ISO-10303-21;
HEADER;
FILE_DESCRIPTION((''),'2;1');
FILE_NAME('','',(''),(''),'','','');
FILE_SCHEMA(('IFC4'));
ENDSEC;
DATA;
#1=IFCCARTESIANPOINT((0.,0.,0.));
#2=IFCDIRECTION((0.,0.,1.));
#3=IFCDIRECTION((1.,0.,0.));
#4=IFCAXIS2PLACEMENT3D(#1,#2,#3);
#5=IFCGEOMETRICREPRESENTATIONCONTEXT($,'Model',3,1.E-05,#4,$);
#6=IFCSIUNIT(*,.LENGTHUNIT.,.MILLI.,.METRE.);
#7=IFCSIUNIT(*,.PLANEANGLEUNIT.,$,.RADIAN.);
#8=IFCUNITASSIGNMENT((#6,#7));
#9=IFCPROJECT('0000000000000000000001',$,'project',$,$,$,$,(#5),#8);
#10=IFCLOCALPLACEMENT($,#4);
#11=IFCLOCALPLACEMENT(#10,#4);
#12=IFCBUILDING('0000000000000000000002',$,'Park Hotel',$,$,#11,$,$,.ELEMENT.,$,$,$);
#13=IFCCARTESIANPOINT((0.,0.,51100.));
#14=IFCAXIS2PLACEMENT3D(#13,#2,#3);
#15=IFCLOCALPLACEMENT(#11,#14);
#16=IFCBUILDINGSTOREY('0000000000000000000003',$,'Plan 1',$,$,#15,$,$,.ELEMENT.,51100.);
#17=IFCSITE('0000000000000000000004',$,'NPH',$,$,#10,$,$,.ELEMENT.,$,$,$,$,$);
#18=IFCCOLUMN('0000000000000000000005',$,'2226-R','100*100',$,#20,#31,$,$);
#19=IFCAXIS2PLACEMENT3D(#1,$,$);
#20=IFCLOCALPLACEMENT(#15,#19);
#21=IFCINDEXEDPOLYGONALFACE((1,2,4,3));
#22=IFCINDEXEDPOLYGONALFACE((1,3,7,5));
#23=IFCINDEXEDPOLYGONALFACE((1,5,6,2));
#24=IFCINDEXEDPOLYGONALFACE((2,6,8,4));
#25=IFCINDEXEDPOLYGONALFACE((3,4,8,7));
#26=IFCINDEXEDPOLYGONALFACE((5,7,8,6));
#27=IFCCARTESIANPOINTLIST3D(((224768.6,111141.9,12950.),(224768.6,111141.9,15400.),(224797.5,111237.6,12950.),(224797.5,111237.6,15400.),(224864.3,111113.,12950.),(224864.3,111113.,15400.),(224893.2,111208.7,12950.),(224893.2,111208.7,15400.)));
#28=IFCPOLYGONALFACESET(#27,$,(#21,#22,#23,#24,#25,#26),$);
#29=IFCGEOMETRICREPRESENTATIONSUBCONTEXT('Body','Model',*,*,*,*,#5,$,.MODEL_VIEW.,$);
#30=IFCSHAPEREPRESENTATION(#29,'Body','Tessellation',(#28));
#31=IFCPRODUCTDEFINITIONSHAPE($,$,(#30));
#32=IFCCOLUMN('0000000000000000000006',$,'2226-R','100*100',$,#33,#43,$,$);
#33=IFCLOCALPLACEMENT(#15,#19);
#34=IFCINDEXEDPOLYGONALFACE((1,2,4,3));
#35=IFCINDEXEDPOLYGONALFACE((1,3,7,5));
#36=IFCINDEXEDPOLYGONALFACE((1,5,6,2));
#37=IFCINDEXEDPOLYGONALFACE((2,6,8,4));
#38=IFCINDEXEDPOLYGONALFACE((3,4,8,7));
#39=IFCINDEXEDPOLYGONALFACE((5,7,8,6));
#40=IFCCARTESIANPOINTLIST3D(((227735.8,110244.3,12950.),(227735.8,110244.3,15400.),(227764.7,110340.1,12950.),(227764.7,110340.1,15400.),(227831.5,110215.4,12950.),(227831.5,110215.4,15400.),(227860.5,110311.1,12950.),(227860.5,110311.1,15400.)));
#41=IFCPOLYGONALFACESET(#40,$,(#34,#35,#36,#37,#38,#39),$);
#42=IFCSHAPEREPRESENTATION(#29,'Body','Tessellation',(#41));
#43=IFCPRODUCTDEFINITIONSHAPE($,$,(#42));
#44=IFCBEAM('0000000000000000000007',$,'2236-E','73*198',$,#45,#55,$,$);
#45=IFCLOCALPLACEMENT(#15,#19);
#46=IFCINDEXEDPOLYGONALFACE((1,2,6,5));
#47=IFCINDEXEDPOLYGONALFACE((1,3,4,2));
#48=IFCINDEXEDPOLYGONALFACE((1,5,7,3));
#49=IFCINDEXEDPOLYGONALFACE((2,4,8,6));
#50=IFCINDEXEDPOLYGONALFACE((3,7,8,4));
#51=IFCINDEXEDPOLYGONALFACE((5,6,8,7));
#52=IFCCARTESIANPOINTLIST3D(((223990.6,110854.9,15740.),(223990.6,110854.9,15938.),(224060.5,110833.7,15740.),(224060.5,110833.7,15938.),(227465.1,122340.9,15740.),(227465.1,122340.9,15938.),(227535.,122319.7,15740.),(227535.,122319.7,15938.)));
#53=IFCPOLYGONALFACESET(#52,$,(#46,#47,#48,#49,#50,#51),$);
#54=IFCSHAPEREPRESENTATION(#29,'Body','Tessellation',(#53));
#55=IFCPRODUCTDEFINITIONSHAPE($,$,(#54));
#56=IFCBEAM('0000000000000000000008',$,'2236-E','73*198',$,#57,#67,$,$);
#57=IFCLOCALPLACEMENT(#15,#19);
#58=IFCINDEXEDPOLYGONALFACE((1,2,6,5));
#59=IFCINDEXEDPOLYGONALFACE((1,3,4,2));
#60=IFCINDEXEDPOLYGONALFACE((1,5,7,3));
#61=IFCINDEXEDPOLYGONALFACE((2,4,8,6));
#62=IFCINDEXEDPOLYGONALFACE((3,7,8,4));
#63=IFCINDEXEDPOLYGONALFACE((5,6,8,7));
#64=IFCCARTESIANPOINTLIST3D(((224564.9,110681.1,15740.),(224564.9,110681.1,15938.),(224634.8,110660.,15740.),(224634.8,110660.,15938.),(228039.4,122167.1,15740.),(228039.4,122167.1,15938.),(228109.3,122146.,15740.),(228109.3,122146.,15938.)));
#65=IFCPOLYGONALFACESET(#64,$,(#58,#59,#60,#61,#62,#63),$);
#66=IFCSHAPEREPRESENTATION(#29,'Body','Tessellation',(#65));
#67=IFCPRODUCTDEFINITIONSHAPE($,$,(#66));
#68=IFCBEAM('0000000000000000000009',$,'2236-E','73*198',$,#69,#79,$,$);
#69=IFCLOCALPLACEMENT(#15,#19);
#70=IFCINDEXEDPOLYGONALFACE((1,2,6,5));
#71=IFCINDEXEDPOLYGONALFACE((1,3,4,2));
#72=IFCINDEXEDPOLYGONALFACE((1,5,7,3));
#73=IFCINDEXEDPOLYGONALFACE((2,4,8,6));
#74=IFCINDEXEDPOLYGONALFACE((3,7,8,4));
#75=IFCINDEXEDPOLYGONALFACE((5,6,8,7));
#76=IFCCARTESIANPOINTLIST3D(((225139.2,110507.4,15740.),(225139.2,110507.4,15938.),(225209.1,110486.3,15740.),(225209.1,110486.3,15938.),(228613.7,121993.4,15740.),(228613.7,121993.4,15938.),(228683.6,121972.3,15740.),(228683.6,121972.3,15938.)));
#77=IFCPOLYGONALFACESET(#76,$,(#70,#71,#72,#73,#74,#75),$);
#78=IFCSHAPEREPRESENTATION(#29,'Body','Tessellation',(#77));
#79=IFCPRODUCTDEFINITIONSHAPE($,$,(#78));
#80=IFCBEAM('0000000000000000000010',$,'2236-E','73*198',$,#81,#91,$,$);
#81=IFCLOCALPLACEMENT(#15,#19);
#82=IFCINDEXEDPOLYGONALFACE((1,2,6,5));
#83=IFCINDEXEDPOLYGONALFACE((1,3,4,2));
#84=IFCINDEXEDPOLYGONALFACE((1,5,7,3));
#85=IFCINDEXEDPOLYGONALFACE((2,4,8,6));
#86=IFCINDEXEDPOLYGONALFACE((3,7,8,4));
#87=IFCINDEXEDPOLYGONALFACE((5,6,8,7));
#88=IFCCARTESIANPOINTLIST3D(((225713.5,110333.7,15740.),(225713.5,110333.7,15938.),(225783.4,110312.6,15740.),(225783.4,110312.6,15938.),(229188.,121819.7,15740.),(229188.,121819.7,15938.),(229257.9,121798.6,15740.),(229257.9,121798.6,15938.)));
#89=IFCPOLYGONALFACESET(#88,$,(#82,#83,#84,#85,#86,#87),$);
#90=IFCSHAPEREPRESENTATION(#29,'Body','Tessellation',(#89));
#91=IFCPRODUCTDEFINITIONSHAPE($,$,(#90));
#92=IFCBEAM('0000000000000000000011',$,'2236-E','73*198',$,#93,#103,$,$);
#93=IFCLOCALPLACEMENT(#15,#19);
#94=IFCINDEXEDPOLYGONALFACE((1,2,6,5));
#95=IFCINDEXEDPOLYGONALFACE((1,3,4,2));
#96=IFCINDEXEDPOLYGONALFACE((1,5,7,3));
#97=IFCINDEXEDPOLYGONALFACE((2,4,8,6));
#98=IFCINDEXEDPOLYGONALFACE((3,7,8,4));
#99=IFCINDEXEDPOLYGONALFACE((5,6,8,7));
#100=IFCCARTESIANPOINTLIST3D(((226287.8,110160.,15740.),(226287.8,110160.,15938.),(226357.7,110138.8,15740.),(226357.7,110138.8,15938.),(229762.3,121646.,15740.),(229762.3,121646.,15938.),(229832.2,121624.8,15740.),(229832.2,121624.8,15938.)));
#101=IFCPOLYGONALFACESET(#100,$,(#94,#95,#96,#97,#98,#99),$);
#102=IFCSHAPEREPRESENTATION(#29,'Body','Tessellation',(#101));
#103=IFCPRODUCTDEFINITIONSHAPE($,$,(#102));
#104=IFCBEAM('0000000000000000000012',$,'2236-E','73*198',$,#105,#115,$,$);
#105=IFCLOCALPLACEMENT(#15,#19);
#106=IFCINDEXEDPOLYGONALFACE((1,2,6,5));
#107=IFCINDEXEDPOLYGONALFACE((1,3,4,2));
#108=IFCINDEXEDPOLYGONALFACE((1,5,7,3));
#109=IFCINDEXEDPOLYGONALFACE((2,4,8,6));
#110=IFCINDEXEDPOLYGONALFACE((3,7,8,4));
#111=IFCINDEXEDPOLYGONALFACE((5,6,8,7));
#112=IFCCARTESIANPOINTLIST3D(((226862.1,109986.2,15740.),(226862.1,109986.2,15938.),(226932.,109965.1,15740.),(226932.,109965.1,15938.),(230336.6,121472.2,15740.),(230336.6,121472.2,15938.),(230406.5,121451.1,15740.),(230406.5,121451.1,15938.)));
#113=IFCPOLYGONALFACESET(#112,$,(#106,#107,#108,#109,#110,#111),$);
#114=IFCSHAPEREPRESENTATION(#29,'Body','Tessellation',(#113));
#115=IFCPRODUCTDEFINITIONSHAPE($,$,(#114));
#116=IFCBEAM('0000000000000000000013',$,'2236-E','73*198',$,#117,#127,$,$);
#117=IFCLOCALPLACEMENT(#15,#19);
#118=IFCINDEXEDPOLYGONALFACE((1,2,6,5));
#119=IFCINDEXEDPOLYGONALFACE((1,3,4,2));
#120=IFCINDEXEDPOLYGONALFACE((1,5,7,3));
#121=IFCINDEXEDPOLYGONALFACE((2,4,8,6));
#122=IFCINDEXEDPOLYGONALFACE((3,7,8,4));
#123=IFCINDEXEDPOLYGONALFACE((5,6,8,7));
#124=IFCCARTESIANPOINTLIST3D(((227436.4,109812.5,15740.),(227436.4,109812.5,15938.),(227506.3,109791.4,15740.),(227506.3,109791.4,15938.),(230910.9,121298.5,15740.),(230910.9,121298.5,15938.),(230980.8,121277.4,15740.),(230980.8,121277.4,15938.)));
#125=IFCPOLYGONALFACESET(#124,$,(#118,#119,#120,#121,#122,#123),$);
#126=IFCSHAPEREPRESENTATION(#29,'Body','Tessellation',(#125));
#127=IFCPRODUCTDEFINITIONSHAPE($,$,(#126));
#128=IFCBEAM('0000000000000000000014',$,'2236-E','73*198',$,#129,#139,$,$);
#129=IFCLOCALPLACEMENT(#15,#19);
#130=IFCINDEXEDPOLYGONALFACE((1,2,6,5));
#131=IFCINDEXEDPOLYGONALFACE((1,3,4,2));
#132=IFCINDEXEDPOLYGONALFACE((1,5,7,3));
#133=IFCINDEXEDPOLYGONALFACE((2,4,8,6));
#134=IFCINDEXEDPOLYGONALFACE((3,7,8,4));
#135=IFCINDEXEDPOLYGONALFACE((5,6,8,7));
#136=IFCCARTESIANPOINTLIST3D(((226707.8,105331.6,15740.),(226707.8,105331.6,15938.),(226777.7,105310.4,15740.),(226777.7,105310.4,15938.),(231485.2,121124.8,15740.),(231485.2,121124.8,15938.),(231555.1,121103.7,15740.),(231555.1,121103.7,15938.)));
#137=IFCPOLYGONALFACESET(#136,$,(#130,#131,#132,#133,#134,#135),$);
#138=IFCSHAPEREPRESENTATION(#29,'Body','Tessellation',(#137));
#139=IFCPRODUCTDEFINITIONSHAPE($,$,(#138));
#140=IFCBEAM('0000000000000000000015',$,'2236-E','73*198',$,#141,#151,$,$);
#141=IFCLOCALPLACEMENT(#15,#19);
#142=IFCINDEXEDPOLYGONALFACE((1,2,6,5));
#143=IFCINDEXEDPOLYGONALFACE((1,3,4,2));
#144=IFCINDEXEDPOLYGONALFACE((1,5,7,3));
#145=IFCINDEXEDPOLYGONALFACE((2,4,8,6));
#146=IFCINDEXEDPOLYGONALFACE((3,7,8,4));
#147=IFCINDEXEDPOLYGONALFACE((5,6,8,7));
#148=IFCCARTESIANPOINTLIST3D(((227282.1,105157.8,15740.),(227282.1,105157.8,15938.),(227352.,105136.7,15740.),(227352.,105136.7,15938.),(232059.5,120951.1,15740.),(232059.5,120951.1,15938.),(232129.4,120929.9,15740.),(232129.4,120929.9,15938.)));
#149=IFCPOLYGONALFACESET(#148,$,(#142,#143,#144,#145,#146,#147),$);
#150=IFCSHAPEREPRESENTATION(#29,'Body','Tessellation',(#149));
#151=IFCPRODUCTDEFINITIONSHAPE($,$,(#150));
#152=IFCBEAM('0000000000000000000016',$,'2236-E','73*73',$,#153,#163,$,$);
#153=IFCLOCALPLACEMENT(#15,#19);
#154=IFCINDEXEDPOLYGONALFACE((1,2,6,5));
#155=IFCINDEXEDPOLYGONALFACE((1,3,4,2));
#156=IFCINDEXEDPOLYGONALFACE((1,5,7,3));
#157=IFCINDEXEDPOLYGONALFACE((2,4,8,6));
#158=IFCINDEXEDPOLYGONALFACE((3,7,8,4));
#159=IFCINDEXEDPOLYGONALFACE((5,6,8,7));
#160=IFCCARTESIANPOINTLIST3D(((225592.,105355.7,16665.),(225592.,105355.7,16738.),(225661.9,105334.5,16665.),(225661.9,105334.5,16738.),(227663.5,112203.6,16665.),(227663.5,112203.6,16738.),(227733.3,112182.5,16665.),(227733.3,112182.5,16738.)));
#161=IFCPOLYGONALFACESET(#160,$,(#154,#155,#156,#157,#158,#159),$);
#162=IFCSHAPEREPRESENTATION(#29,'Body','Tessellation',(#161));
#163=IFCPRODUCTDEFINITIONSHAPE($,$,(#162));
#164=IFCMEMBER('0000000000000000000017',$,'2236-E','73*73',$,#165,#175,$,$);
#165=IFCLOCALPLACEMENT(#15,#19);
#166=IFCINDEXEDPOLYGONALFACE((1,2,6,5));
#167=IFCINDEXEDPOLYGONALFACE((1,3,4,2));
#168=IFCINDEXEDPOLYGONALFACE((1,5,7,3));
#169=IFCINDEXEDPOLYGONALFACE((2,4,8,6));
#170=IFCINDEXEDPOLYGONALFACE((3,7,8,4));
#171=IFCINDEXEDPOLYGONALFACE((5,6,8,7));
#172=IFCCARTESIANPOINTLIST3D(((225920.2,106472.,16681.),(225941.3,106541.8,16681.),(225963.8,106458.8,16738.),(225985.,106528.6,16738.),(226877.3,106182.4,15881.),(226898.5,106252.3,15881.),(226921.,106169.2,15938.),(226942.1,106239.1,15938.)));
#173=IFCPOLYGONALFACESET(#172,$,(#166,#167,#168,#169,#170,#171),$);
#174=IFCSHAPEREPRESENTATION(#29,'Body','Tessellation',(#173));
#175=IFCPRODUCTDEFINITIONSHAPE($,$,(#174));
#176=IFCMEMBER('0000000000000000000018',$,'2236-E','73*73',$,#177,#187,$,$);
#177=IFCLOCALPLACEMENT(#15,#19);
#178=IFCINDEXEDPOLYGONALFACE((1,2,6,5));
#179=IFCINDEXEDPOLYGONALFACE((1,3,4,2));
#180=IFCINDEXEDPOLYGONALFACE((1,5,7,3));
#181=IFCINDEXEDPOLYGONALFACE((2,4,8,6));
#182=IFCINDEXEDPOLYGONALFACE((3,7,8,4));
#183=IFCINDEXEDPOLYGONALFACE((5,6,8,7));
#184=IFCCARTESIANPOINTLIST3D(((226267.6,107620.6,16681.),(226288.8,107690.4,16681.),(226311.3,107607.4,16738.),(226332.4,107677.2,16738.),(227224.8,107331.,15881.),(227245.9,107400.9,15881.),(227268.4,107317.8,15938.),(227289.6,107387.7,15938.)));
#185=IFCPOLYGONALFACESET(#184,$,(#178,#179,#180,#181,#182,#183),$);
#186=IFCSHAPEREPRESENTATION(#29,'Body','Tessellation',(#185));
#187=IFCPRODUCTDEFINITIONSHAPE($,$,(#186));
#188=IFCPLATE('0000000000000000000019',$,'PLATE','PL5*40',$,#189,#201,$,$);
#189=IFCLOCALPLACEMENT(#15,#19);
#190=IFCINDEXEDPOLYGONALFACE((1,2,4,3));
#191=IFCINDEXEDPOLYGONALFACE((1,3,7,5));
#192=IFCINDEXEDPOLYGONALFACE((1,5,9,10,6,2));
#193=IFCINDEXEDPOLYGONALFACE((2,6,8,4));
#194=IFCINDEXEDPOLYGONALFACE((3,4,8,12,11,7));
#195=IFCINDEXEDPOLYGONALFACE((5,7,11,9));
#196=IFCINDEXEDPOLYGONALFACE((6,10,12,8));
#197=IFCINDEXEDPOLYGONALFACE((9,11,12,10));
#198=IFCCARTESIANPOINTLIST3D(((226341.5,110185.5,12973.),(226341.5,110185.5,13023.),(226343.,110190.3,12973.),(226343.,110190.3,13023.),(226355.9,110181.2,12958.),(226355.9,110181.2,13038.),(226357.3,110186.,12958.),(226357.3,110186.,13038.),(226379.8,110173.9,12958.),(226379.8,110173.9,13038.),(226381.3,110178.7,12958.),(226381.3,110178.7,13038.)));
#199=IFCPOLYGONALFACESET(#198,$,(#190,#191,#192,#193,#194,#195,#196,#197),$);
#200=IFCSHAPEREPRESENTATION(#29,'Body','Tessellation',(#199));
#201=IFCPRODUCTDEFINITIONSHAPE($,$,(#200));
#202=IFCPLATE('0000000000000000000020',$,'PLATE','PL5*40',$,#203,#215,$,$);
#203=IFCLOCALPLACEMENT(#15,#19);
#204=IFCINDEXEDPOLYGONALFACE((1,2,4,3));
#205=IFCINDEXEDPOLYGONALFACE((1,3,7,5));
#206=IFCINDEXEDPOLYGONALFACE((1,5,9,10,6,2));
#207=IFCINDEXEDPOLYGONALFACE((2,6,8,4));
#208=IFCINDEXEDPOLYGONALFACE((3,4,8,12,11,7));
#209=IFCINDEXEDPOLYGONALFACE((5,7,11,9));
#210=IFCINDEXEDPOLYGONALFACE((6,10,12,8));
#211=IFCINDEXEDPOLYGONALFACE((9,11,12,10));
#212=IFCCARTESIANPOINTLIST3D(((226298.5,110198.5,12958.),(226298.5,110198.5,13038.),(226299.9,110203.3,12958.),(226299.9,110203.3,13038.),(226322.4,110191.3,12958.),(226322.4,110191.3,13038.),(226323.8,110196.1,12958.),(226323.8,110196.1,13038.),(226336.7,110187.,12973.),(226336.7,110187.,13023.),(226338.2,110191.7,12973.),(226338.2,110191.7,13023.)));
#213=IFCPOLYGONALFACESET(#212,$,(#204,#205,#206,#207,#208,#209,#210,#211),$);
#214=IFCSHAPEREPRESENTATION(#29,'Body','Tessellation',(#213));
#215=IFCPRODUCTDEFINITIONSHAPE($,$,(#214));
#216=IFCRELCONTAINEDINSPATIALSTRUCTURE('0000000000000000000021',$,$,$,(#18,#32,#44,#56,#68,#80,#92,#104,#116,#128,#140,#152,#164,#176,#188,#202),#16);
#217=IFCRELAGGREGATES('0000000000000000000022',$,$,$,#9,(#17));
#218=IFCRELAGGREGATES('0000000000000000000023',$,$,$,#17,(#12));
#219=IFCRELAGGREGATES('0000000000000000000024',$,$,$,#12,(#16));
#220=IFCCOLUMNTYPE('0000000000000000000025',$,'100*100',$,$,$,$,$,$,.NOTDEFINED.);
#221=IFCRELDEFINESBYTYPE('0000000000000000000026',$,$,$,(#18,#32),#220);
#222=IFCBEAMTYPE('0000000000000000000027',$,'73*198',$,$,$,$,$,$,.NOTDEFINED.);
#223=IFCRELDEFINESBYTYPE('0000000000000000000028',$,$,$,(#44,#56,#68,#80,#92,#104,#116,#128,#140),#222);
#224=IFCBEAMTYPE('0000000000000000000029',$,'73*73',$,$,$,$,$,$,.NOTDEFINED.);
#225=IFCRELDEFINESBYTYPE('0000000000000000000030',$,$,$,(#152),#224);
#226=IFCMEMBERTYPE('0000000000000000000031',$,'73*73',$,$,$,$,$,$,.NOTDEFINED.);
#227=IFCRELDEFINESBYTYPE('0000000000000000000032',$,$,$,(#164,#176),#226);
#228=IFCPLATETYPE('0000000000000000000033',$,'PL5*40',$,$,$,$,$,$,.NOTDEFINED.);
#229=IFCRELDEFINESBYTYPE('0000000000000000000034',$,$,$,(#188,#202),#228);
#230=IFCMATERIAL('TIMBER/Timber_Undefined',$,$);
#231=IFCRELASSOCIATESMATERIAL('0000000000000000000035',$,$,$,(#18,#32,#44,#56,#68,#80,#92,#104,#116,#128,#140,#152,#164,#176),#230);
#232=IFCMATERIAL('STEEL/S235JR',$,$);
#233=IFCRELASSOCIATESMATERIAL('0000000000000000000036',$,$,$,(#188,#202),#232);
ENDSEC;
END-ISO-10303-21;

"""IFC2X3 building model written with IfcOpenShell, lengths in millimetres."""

from ifc_helpers import new_model, si_unit, frame, origin_with_axes, origin_2d_with_axis, place, context, subcontext, project, spatial, polyline, rectangle, outline, extrude, material, type_object, element, save


model = new_model("IFC2X3")

# Units and contexts
model_context = context("Model", 3, precision=1e-05, world=origin_with_axes())
body_context = subcontext(model_context, "Body", "Model", "MODEL_VIEW")
ifc_project = project(units=[si_unit("LENGTHUNIT", "METRE", prefix="MILLI"), si_unit("PLANEANGLEUNIT", "RADIAN")], contexts=[model_context])

# Site, building, storey
site_placement = place(None, origin_with_axes())
site = spatial("IfcSite", under=ifc_project, at=site_placement, Name="NPH", CompositionType="ELEMENT")
building_placement = place(site_placement, origin_with_axes())
building = spatial("IfcBuilding", under=site, at=building_placement, Name="Park Hotel", CompositionType="ELEMENT")
storey_placement = place(building_placement, frame((0.0, 0.0, 51100.0), z_axis=(0.0, 0.0, 1.0), x_axis=(1.0, 0.0, 0.0)))
storey = spatial("IfcBuildingStorey", under=building, at=storey_placement, Name="Plan 1", CompositionType="ELEMENT", Elevation=51100.0)

# Columns
ifc_material_1 = material(Name="TIMBER/Timber_Undefined")
column_type = type_object("IfcColumnType", Name="100*100", PredefinedType="NOTDEFINED")
for number, where, z_axis, x_axis, name in (
    (1, (224830.9, 111175.3, 15400.0), (0.0, 0.0, -1.0), (0.289538, 0.957167, 0.0), "2226-R"),
    (2, (227798.1, 110277.7, 15400.0), (0.0, 0.0, -1.0), (0.289538, 0.957167, 0.0), "2226-R"),
):
    element("IfcColumn", number, at=place(storey_placement, frame(where, z_axis=z_axis, x_axis=x_axis)), inside=storey, type_object=column_type, material=ifc_material_1, Name=name, Description="100*100", context=body_context, shape_type="SweptSolid", body=[
        extrude(rectangle(XDim=100.0, YDim=100.0, at=origin_2d_with_axis()), frame((0.0, 0.0, 2450.0), z_axis=(0.0, 0.0, -1.0), x_axis=(0.0, 1.0, 0.0)), (0.0, 0.0, 1.0), 2450.0),
    ])

# Beams
beam_type_1 = type_object("IfcBeamType", Name="73*198", PredefinedType="NOTDEFINED")
for number, where, z_axis, x_axis, name in (
    (3, (224025.6, 110844.3, 15839.0), (-0.957167, 0.289538, 0.0), (0.289538, 0.957167, 0.0), "2236-E"),
    (4, (224599.9, 110670.6, 15839.0), (-0.957167, 0.289538, 0.0), (0.289538, 0.957167, 0.0), "2236-E"),
    (5, (225174.2, 110496.8, 15839.0), (-0.957167, 0.289538, 0.0), (0.289538, 0.957167, 0.0), "2236-E"),
    (6, (225748.5, 110323.1, 15839.0), (-0.957167, 0.289538, 0.0), (0.289538, 0.957167, 0.0), "2236-E"),
    (7, (226322.8, 110149.4, 15839.0), (-0.957167, 0.289538, 0.0), (0.289538, 0.957167, 0.0), "2236-E"),
    (8, (226897.1, 109975.7, 15839.0), (-0.957167, 0.289538, 0.0), (0.289538, 0.957167, 0.0), "2236-E"),
    (9, (227471.4, 109802.0, 15839.0), (-0.957167, 0.289538, 0.0), (0.289538, 0.957167, 0.0), "2236-E"),
):
    element("IfcBeam", number, at=place(storey_placement, frame(where, z_axis=z_axis, x_axis=x_axis)), inside=storey, type_object=beam_type_1, material=ifc_material_1, Name=name, Description="73*198", context=body_context, shape_type="SweptSolid", body=[
        extrude(rectangle(XDim=198.0, YDim=73.0, at=origin_2d_with_axis()), frame((12000.0, 0.0, 0.0), z_axis=(-1.0, 0.0, 0.0), x_axis=(0.0, -1.0, 0.0)), (0.0, 0.0, 1.0), 12000.0),
    ])
for number, where, z_axis, x_axis, name in (
    (10, (226742.8, 105321.0, 15839.0), (-0.957167, 0.289538, 0.0), (0.289538, 0.957167, 0.0), "2236-E"),
    (11, (227317.1, 105147.3, 15839.0), (-0.957167, 0.289538, 0.0), (0.289538, 0.957167, 0.0), "2236-E"),
):
    element("IfcBeam", number, at=place(storey_placement, frame(where, z_axis=z_axis, x_axis=x_axis)), inside=storey, type_object=beam_type_1, material=ifc_material_1, Name=name, Description="73*198", context=body_context, shape_type="SweptSolid", body=[
        extrude(rectangle(XDim=198.0, YDim=73.0, at=origin_2d_with_axis()), frame((16500.0, 0.0, 0.0), z_axis=(-1.0, 0.0, 0.0), x_axis=(0.0, -1.0, 0.0)), (0.0, 0.0, 1.0), 16500.0),
    ])
beam_type_2 = type_object("IfcBeamType", Name="73*73", PredefinedType="NOTDEFINED")
beam_1_placement = place(storey_placement, frame((225626.9, 105345.1, 16701.5), z_axis=(-0.957167, 0.289538, 0.0), x_axis=(0.289538, 0.957167, 0.0)))
element("IfcBeam", 12, at=beam_1_placement, inside=storey, type_object=beam_type_2, material=ifc_material_1, Name="2236-E", Description="73*73", context=body_context, shape_type="SweptSolid", body=[
    extrude(rectangle(XDim=73.0, YDim=73.0, at=origin_2d_with_axis()), frame((7154.4, 0.0, 0.0), z_axis=(-1.0, 0.0, 0.0), x_axis=(0.0, -1.0, 0.0)), (0.0, 0.0, 1.0), 7154.4),
])

# Members
member_type = type_object("IfcMemberType", Name="73*73", PredefinedType="NOTDEFINED")
for number, where, z_axis, x_axis, name in (
    (13, (225952.6, 106500.3, 16709.5), (0.289538, 0.957167, 0.0), (0.747421, -0.226091, -0.624695), "2236-E"),
    (14, (226300.0, 107648.9, 16709.5), (0.289538, 0.957167, 0.0), (0.747421, -0.226091, -0.624695), "2236-E"),
):
    element("IfcMember", number, at=place(storey_placement, frame(where, z_axis=z_axis, x_axis=x_axis)), inside=storey, type_object=member_type, material=ifc_material_1, Name=name, Description="73*73", context=body_context, shape_type="SweptSolid", body=[
        extrude(rectangle(XDim=73.0, YDim=73.0, at=origin_2d_with_axis()), frame((1280.6, 0.0, 0.0), z_axis=(-1.0, 0.0, 0.0), x_axis=(0.0, -1.0, 0.0)), (0.0, 0.0, 1.0), 1280.6),
    ])

# Plates
ifc_material_2 = material(Name="STEEL/S235JR")
plate_type = type_object("IfcPlateType", Name="PL5*40", PredefinedType="NOTDEFINED")
plate_1_placement = place(storey_placement, frame((226380.5, 110176.3, 12958.0), z_axis=(0.289538, 0.957167, 0.0), x_axis=(-0.957167, 0.289538, 0.0)))
element("IfcPlate", 15, at=plate_1_placement, inside=storey, type_object=plate_type, material=ifc_material_2, Name="PLATE", Description="PL5*40", context=body_context, shape_type="SweptSolid", body=[
    extrude(outline(polyline([(0.0, 0.0), (25.0, 0.0), (40.0, 15.0), (40.0, 65.0), (25.0, 80.0), (0.0, 80.0), (0.0, 0.0)])), frame((0.0, 0.0, -2.5), z_axis=(0.0, 0.0, 1.0), x_axis=(1.0, 0.0, 0.0)), (0.0, 0.0, 1.0), 5.0),
])
plate_2_placement = place(storey_placement, frame((226337.5, 110189.4, 12958.0), z_axis=(0.289538, 0.957167, 0.0), x_axis=(-0.957167, 0.289538, 0.0)))
element("IfcPlate", 16, at=plate_2_placement, inside=storey, type_object=plate_type, material=ifc_material_2, Name="PLATE", Description="PL5*40", context=body_context, shape_type="SweptSolid", body=[
    extrude(outline(polyline([(0.0, 15.0), (15.0, 0.0), (40.0, 0.0), (40.0, 80.0), (15.0, 80.0), (0.0, 65.0), (0.0, 15.0)])), frame((0.0, 0.0, -2.5), z_axis=(0.0, 0.0, 1.0), x_axis=(1.0, 0.0, 0.0)), (0.0, 0.0, 1.0), 5.0),
])

save(model, "model.ifc")
